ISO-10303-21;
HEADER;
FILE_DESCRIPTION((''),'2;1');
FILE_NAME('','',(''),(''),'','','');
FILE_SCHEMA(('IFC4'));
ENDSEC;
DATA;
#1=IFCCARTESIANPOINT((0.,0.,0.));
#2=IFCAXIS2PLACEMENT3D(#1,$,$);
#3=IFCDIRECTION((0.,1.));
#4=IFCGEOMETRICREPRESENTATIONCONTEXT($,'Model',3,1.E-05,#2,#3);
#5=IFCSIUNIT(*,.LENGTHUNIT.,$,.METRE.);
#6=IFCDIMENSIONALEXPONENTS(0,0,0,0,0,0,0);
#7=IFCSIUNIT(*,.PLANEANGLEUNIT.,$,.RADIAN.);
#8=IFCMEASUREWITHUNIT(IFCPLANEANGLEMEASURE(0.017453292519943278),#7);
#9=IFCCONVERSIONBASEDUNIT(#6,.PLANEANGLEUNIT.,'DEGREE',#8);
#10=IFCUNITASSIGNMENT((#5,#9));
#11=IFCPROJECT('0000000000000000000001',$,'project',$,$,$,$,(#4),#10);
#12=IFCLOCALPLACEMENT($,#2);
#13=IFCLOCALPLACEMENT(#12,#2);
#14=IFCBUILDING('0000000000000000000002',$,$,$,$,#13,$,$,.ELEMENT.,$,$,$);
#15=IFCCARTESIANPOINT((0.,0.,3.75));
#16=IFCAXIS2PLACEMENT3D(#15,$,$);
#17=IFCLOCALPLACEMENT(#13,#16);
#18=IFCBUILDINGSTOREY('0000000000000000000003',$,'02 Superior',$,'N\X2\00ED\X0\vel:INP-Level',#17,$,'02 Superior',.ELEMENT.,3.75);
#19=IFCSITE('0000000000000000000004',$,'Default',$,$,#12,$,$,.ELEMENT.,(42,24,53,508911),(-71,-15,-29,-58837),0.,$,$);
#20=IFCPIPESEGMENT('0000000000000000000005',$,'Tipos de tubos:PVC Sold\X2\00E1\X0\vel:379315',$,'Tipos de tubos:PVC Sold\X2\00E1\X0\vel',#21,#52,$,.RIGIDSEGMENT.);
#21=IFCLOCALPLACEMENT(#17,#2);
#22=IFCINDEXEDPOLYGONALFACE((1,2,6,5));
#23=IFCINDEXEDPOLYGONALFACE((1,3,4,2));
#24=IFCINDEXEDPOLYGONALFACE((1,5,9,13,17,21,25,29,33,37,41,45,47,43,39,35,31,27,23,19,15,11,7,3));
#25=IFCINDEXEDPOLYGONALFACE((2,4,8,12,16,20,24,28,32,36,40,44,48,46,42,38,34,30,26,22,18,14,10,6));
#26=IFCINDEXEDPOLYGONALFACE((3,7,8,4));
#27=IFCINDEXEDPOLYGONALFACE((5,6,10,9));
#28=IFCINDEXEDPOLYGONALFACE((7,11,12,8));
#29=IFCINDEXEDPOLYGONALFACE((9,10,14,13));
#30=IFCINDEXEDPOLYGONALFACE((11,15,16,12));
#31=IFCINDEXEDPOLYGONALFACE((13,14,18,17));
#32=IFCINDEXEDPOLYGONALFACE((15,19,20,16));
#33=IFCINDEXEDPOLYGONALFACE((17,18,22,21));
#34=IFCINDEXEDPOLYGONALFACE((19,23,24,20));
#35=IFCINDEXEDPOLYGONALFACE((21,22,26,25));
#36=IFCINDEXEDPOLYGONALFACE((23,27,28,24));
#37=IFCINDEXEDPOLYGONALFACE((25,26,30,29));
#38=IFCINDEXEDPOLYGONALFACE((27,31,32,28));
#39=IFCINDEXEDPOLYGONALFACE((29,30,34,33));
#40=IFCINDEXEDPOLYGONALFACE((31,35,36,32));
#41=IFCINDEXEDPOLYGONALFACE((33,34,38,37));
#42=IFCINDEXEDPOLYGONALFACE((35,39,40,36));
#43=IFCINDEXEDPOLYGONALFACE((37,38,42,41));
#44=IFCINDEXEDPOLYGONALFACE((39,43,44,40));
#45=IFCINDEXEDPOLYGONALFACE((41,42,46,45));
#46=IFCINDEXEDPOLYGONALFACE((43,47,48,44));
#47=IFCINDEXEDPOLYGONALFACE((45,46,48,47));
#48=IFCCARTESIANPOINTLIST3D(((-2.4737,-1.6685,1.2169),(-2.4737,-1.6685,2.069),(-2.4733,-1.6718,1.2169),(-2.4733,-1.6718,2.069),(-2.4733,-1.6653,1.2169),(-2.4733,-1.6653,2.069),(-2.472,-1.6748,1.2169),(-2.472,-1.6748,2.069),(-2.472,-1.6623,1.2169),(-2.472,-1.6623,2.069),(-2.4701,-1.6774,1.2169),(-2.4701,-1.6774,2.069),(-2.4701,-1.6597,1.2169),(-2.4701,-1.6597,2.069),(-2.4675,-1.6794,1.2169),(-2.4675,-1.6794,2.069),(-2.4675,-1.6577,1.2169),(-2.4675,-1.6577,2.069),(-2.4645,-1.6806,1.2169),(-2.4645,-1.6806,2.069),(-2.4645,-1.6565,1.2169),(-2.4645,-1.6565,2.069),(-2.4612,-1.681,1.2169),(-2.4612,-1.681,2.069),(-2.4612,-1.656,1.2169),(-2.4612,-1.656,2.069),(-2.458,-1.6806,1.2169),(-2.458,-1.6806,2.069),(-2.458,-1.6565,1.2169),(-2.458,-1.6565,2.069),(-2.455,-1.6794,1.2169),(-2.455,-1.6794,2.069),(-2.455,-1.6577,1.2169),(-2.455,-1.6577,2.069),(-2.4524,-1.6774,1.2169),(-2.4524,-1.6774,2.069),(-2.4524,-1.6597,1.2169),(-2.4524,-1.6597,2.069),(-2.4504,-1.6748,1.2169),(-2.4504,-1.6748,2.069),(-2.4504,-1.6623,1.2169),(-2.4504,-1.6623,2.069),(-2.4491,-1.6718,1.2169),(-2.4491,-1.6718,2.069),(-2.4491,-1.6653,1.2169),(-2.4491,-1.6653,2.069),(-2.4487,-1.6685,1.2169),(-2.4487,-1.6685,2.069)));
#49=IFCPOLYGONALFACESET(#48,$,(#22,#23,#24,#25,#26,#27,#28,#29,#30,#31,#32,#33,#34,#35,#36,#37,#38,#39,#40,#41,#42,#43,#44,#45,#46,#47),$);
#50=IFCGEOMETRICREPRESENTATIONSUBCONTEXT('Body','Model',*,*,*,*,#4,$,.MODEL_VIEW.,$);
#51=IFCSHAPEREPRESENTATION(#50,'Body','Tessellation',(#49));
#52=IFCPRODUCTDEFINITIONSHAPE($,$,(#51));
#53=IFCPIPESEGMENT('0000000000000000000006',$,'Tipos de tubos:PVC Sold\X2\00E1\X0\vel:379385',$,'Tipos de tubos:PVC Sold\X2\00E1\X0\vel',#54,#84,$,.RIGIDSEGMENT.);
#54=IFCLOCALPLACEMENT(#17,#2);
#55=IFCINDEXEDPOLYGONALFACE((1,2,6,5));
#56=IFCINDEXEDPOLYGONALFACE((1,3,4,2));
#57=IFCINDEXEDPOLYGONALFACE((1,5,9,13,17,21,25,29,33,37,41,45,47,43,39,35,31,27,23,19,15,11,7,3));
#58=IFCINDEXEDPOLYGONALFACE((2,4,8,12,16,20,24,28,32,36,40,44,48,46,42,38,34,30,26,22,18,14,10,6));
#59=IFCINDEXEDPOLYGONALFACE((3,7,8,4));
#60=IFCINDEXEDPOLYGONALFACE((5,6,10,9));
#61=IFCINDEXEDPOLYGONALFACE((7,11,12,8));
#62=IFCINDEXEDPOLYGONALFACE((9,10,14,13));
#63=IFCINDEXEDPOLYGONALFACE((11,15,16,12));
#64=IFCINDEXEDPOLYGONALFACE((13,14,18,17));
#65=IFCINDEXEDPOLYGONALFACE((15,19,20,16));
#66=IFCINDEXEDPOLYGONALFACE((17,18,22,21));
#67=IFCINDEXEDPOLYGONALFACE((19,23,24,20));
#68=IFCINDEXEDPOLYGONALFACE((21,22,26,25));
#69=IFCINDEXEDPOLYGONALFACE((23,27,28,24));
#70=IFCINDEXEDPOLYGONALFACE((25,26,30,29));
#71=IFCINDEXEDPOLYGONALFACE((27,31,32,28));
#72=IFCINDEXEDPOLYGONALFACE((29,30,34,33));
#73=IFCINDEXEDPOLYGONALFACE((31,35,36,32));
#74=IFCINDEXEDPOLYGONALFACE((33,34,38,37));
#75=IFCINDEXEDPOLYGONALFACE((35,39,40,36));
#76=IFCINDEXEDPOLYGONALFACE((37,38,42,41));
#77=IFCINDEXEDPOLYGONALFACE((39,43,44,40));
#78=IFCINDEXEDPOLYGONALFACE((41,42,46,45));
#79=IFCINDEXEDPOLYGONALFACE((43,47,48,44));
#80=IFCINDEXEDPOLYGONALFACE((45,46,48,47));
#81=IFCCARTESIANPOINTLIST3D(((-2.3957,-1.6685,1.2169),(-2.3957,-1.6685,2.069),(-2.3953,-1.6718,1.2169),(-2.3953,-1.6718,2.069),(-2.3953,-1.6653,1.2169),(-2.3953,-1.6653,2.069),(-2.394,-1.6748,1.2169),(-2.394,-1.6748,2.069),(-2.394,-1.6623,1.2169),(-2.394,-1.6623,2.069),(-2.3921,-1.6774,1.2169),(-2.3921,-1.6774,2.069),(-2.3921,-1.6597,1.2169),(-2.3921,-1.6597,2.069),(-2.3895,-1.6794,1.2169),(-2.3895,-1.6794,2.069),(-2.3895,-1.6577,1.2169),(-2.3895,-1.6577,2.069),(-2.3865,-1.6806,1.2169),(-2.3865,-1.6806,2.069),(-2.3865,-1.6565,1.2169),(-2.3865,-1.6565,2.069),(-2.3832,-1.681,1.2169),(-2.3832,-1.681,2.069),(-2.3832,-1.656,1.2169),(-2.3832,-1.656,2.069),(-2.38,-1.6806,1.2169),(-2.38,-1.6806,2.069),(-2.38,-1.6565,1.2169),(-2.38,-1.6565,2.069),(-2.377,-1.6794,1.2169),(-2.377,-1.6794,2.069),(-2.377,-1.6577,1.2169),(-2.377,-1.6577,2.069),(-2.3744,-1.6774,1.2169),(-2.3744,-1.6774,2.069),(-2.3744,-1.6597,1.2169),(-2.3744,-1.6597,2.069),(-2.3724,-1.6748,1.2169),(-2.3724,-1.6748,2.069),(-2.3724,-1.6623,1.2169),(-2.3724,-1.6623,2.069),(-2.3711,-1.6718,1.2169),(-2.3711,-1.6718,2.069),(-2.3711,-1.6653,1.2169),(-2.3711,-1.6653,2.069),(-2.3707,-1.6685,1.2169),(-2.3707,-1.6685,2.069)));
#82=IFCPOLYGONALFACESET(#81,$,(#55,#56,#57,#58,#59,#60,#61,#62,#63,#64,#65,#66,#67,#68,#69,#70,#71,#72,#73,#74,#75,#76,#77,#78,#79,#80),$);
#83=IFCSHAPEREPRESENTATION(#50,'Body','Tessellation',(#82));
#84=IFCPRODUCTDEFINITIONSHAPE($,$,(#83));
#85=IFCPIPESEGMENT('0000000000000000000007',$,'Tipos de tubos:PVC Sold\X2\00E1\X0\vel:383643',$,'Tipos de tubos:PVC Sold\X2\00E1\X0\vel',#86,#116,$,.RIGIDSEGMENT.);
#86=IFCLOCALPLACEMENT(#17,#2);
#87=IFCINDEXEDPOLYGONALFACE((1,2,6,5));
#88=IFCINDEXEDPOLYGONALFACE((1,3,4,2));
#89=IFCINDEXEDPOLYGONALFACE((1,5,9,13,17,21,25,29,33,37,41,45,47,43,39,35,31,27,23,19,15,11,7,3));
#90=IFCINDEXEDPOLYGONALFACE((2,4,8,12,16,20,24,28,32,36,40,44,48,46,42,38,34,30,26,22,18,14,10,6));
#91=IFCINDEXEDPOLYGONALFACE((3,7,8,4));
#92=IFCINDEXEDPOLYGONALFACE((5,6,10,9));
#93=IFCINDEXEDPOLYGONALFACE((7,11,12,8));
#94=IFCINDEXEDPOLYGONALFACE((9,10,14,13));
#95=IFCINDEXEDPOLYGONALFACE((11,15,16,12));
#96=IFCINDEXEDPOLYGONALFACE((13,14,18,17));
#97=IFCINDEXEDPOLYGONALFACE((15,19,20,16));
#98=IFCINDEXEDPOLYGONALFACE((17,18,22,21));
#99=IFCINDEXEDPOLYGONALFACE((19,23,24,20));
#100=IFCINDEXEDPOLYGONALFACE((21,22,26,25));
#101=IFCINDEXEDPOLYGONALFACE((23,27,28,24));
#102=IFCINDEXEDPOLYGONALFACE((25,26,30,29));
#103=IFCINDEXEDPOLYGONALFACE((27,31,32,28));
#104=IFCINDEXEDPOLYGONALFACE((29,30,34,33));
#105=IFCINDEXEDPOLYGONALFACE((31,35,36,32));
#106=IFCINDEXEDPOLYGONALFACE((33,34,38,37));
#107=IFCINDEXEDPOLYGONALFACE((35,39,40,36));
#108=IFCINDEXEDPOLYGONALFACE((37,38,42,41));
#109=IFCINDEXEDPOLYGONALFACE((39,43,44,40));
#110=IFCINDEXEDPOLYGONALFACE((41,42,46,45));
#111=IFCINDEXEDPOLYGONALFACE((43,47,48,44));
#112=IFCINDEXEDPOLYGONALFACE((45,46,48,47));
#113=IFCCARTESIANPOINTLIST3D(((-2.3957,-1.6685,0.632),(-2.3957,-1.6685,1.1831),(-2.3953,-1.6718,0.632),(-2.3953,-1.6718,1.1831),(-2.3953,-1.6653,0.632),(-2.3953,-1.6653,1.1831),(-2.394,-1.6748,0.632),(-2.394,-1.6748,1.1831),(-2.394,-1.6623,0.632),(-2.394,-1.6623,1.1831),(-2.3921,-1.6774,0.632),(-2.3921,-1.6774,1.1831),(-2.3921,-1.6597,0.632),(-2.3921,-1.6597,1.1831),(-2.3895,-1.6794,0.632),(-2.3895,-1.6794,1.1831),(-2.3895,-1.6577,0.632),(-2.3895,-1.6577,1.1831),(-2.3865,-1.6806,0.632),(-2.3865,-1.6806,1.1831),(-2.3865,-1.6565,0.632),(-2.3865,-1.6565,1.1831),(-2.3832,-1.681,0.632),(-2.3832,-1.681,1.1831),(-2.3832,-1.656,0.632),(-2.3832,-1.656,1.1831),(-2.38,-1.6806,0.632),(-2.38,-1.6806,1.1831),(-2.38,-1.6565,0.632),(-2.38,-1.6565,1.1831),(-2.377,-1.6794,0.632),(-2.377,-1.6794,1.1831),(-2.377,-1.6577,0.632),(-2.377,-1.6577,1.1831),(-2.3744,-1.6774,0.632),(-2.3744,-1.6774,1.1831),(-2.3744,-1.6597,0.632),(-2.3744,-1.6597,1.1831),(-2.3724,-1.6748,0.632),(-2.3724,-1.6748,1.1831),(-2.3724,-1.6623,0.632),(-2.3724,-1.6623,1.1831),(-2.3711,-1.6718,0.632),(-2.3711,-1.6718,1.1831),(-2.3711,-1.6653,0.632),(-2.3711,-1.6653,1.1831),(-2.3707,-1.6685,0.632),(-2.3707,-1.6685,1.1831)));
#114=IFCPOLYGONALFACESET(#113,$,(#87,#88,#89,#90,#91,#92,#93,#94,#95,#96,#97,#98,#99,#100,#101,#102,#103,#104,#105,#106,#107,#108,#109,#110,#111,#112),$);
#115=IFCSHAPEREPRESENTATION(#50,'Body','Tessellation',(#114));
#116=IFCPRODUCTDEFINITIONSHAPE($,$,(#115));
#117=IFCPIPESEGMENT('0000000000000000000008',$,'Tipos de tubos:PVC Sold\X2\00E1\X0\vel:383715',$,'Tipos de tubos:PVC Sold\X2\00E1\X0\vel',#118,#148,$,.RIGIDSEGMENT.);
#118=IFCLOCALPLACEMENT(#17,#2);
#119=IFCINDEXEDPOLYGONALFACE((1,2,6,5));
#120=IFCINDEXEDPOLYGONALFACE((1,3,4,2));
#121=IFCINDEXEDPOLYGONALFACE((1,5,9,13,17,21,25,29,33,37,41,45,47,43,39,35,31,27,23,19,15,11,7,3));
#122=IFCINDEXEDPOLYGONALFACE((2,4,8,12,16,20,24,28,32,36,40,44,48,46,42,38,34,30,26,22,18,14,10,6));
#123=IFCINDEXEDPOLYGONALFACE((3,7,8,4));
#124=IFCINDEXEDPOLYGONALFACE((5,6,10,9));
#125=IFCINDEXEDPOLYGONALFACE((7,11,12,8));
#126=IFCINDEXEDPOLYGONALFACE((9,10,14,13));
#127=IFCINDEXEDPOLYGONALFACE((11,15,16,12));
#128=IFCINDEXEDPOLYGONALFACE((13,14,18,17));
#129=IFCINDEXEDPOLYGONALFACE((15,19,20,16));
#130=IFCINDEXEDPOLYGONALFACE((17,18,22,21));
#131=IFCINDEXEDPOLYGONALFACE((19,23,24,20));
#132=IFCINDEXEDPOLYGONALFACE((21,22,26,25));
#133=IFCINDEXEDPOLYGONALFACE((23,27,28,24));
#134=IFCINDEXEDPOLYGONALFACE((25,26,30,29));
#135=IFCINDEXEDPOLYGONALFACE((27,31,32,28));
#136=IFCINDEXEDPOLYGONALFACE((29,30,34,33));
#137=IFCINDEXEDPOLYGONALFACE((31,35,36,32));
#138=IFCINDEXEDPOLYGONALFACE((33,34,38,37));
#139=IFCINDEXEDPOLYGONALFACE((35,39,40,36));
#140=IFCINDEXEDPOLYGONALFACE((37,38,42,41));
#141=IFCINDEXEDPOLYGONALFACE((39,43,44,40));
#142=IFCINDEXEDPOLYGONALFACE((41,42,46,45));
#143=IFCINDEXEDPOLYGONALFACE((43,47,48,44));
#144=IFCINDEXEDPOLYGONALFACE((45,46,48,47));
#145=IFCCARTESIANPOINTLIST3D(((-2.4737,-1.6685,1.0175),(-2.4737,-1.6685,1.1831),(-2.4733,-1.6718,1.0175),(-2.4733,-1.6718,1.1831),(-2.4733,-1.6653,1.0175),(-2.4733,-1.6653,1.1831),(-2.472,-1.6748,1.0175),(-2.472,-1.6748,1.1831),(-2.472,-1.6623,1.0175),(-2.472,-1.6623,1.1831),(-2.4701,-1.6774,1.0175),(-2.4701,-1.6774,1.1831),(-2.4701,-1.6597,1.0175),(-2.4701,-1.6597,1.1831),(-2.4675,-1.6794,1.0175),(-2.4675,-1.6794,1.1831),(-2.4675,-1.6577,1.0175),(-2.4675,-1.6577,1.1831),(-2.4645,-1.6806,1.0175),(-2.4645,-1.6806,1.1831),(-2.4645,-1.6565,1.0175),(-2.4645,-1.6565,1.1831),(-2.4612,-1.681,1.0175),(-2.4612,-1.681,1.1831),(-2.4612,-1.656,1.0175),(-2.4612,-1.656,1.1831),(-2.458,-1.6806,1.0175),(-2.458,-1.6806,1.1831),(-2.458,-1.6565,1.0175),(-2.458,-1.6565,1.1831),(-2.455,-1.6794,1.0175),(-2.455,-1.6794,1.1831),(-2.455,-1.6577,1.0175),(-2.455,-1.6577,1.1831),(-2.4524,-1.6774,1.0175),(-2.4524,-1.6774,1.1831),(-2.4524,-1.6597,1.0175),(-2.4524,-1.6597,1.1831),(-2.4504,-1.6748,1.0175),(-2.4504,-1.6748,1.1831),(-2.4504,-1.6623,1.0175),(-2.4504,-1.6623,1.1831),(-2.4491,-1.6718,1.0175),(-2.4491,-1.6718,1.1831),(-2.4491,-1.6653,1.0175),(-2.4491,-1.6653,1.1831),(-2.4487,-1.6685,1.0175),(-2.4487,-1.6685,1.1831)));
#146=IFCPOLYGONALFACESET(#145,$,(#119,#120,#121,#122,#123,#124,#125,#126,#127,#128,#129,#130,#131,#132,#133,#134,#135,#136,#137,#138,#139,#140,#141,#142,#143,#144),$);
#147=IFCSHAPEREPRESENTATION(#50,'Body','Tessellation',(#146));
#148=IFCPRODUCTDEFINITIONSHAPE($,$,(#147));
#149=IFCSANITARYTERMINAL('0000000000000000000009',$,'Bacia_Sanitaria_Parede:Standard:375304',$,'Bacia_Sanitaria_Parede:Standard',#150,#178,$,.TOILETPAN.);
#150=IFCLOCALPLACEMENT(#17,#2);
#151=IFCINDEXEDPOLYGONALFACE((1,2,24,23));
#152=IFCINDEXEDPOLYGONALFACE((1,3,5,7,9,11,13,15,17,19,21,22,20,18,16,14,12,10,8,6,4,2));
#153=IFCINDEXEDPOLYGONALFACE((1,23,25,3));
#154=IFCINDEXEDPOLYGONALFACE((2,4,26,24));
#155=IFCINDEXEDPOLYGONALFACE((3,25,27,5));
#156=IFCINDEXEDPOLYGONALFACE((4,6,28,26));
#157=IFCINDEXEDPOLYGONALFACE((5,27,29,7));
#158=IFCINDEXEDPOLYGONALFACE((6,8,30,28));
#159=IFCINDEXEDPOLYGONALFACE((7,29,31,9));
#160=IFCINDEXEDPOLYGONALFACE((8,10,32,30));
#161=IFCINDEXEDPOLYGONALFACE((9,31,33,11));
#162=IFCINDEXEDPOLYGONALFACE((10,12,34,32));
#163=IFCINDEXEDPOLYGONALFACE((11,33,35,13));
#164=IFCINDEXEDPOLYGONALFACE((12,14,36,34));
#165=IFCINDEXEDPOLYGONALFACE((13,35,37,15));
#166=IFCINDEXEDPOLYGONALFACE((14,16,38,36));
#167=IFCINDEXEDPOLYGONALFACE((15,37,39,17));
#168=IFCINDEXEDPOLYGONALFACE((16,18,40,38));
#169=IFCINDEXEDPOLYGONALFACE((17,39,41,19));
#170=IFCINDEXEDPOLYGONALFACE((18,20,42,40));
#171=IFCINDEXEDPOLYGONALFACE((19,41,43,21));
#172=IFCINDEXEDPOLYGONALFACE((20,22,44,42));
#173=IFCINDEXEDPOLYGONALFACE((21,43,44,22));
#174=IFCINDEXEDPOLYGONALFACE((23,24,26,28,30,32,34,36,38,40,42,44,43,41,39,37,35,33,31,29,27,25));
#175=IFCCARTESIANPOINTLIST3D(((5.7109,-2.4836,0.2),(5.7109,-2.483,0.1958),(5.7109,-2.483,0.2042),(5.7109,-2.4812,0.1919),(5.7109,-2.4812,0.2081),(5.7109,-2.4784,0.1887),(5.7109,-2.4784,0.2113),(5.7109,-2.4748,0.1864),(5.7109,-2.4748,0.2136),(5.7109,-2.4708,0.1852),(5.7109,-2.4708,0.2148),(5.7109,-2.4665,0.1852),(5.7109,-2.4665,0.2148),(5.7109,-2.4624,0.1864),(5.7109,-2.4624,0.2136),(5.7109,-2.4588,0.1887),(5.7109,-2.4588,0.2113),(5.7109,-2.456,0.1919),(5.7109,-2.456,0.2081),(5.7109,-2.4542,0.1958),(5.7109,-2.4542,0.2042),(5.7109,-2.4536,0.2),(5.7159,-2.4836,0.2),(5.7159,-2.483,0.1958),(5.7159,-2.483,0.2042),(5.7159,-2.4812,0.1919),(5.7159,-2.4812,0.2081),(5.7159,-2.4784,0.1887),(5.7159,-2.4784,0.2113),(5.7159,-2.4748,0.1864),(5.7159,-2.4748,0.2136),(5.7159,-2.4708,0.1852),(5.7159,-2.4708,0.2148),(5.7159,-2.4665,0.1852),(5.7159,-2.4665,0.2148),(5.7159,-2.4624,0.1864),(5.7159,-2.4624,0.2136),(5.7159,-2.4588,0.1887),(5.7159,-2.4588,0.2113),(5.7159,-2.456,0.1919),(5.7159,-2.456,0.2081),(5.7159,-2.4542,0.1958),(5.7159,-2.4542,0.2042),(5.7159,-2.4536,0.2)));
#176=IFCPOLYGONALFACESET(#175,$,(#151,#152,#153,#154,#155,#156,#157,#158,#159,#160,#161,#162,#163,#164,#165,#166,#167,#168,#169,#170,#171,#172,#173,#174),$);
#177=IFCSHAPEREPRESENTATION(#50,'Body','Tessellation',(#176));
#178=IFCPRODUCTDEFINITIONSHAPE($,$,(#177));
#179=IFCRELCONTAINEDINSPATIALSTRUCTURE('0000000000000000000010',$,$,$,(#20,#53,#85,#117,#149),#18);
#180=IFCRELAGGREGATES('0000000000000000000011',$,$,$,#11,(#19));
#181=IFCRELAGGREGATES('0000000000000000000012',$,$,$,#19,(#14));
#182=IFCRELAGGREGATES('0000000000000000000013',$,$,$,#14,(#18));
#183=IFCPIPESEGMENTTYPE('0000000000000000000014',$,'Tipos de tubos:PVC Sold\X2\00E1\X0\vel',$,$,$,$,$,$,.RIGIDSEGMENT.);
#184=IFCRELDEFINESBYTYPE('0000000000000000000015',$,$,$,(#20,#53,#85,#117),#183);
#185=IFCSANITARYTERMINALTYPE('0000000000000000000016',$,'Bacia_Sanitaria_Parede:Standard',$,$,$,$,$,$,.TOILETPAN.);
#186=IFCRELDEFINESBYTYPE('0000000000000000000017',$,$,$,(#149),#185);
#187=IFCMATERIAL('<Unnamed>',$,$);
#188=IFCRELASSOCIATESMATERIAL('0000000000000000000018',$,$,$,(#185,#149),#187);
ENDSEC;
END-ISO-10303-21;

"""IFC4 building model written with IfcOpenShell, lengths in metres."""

from ifc_helpers import new_model, entity, si_unit, converted_unit, direction, frame, origin, place, context, subcontext, project, spatial, arc, indexed_curve, outline, extrude, source, transform, mapped, material, type_object, type_shapes, element, save


model = new_model("IFC4")

# Units and contexts
model_context = context("Model", 3, precision=1e-05, world=origin(), true_north=direction((0.0, 1.0)))
body_context = subcontext(model_context, "Body", "Model", "MODEL_VIEW")
ifc_project = project(units=[si_unit("LENGTHUNIT", "METRE"), converted_unit("PLANEANGLEUNIT", "DEGREE", entity("IfcPlaneAngleMeasure", 0.017453292519943278), si_unit("PLANEANGLEUNIT", "RADIAN"), dimensions=[0, 0, 0, 0, 0, 0, 0])], contexts=[model_context])

# Site, building, storey
site_placement = place(None, origin())
site = spatial("IfcSite", under=ifc_project, at=site_placement, Name="Default", CompositionType="ELEMENT", RefLatitude=(42, 24, 53, 508911), RefLongitude=(-71, -15, -29, -58837), RefElevation=0.0)
building_placement = place(site_placement, origin())
building = spatial("IfcBuilding", under=site, at=building_placement, CompositionType="ELEMENT")
storey_placement = place(building_placement, frame((0.0, 0.0, 3.75)))
storey = spatial("IfcBuildingStorey", under=building, at=storey_placement, Name="02 Superior", ObjectType="Nível:INP-Level", LongName="02 Superior", CompositionType="ELEMENT", Elevation=3.75)

# Pipe segments
pipe_segment_type = type_object("IfcPipeSegmentType", Name="Tipos de tubos:PVC Soldável", PredefinedType="RIGIDSEGMENT")
pipe_segment_1_placement = place(storey_placement, origin())
element("IfcPipeSegment", 1, at=pipe_segment_1_placement, inside=storey, type_object=pipe_segment_type, Name="Tipos de tubos:PVC Soldável:379315", ObjectType="Tipos de tubos:PVC Soldável", PredefinedType="RIGIDSEGMENT", context=body_context, shape_type="SweptSolid", body=[
    extrude(outline(indexed_curve([(0.0125, 0.0), (0.0088, 0.0088), (0.0, 0.0125), (-0.0088, 0.0088), (-0.0125, 0.0), (-0.0088, -0.0088), (0.0, -0.0125), (0.0088, -0.0088)], segments=[arc(1, 2, 3), arc(3, 4, 5), arc(5, 6, 7), arc(7, 8, 1)], self_intersect=False)), frame((-2.4612, -1.6685, 1.2169), z_axis=(0.0, 0.0, 1.0), x_axis=(-1.0, 0.0, 0.0)), (0.0, 0.0, 1.0), 0.8521),
])
pipe_segment_2_placement = place(storey_placement, origin())
element("IfcPipeSegment", 2, at=pipe_segment_2_placement, inside=storey, type_object=pipe_segment_type, Name="Tipos de tubos:PVC Soldável:379385", ObjectType="Tipos de tubos:PVC Soldável", PredefinedType="RIGIDSEGMENT", context=body_context, shape_type="SweptSolid", body=[
    extrude(outline(indexed_curve([(0.0125, 0.0), (0.0088, 0.0088), (0.0, 0.0125), (-0.0088, 0.0088), (-0.0125, 0.0), (-0.0088, -0.0088), (0.0, -0.0125), (0.0088, -0.0088)], segments=[arc(1, 2, 3), arc(3, 4, 5), arc(5, 6, 7), arc(7, 8, 1)], self_intersect=False)), frame((-2.3832, -1.6685, 1.2169), z_axis=(0.0, 0.0, 1.0), x_axis=(-1.0, 0.0, 0.0)), (0.0, 0.0, 1.0), 0.8521),
])
pipe_segment_3_placement = place(storey_placement, origin())
element("IfcPipeSegment", 3, at=pipe_segment_3_placement, inside=storey, type_object=pipe_segment_type, Name="Tipos de tubos:PVC Soldável:383643", ObjectType="Tipos de tubos:PVC Soldável", PredefinedType="RIGIDSEGMENT", context=body_context, shape_type="SweptSolid", body=[
    extrude(outline(indexed_curve([(0.0125, 0.0), (0.0088, 0.0088), (0.0, 0.0125), (-0.0088, 0.0088), (-0.0125, 0.0), (-0.0088, -0.0088), (0.0, -0.0125), (0.0088, -0.0088)], segments=[arc(1, 2, 3), arc(3, 4, 5), arc(5, 6, 7), arc(7, 8, 1)], self_intersect=False)), frame((-2.3832, -1.6685, 0.632), z_axis=(0.0, 0.0, 1.0), x_axis=(-1.0, 0.0, 0.0)), (0.0, 0.0, 1.0), 0.5511),
])
pipe_segment_4_placement = place(storey_placement, origin())
element("IfcPipeSegment", 4, at=pipe_segment_4_placement, inside=storey, type_object=pipe_segment_type, Name="Tipos de tubos:PVC Soldável:383715", ObjectType="Tipos de tubos:PVC Soldável", PredefinedType="RIGIDSEGMENT", context=body_context, shape_type="SweptSolid", body=[
    extrude(outline(indexed_curve([(0.0125, 0.0), (0.0088, 0.0088), (0.0, 0.0125), (-0.0088, 0.0088), (-0.0125, 0.0), (-0.0088, -0.0088), (0.0, -0.0125), (0.0088, -0.0088)], segments=[arc(1, 2, 3), arc(3, 4, 5), arc(5, 6, 7), arc(7, 8, 1)], self_intersect=False)), frame((-2.4612, -1.6685, 1.0175), z_axis=(0.0, 0.0, 1.0), x_axis=(-1.0, 0.0, 0.0)), (0.0, 0.0, 1.0), 0.1656),
])

# Sanitary terminal
ifc_material = material(Name="<Unnamed>")
sanitary_terminal_type_1 = type_object("IfcSanitaryTerminalType", Name="Bacia_Sanitaria_Parede:Standard", PredefinedType="TOILETPAN", material=ifc_material)
shared_shape_1 = source(origin(), body_context, "Body", "SweptSolid", [
    extrude(outline(indexed_curve([(-0.015, 0.0), (0.0, -0.015), (0.015, 0.0), (0.0, 0.015)], segments=[arc(1, 2, 3), arc(3, 4, 1)], self_intersect=False)), frame((0.15, -0.005, 0.2), z_axis=(0.0, 1.0, 0.0), x_axis=(1.0, 0.0, 0.0)), (0.0, 0.0, 1.0), 0.005),
])
type_shapes(sanitary_terminal_type_1, [shared_shape_1])
for number, where, z_axis, x_axis, name in (
    (5, (5.7109, -2.6186, 0.0), (0.0, 0.0, 1.0), (0.0, 1.0, 0.0), "Bacia_Sanitaria_Parede:Standard:375304"),
):
    element("IfcSanitaryTerminal", number, at=place(storey_placement, frame(where, z_axis=z_axis, x_axis=x_axis)), inside=storey, type_object=sanitary_terminal_type_1, material=ifc_material, Name=name, ObjectType="Bacia_Sanitaria_Parede:Standard", PredefinedType="TOILETPAN", context=body_context, shape_type="MappedRepresentation", body=[
        mapped(shared_shape_1, transform((0.0, 0.0, 0.0), scale=1.0)),
    ])

save(model, "model.ifc")
